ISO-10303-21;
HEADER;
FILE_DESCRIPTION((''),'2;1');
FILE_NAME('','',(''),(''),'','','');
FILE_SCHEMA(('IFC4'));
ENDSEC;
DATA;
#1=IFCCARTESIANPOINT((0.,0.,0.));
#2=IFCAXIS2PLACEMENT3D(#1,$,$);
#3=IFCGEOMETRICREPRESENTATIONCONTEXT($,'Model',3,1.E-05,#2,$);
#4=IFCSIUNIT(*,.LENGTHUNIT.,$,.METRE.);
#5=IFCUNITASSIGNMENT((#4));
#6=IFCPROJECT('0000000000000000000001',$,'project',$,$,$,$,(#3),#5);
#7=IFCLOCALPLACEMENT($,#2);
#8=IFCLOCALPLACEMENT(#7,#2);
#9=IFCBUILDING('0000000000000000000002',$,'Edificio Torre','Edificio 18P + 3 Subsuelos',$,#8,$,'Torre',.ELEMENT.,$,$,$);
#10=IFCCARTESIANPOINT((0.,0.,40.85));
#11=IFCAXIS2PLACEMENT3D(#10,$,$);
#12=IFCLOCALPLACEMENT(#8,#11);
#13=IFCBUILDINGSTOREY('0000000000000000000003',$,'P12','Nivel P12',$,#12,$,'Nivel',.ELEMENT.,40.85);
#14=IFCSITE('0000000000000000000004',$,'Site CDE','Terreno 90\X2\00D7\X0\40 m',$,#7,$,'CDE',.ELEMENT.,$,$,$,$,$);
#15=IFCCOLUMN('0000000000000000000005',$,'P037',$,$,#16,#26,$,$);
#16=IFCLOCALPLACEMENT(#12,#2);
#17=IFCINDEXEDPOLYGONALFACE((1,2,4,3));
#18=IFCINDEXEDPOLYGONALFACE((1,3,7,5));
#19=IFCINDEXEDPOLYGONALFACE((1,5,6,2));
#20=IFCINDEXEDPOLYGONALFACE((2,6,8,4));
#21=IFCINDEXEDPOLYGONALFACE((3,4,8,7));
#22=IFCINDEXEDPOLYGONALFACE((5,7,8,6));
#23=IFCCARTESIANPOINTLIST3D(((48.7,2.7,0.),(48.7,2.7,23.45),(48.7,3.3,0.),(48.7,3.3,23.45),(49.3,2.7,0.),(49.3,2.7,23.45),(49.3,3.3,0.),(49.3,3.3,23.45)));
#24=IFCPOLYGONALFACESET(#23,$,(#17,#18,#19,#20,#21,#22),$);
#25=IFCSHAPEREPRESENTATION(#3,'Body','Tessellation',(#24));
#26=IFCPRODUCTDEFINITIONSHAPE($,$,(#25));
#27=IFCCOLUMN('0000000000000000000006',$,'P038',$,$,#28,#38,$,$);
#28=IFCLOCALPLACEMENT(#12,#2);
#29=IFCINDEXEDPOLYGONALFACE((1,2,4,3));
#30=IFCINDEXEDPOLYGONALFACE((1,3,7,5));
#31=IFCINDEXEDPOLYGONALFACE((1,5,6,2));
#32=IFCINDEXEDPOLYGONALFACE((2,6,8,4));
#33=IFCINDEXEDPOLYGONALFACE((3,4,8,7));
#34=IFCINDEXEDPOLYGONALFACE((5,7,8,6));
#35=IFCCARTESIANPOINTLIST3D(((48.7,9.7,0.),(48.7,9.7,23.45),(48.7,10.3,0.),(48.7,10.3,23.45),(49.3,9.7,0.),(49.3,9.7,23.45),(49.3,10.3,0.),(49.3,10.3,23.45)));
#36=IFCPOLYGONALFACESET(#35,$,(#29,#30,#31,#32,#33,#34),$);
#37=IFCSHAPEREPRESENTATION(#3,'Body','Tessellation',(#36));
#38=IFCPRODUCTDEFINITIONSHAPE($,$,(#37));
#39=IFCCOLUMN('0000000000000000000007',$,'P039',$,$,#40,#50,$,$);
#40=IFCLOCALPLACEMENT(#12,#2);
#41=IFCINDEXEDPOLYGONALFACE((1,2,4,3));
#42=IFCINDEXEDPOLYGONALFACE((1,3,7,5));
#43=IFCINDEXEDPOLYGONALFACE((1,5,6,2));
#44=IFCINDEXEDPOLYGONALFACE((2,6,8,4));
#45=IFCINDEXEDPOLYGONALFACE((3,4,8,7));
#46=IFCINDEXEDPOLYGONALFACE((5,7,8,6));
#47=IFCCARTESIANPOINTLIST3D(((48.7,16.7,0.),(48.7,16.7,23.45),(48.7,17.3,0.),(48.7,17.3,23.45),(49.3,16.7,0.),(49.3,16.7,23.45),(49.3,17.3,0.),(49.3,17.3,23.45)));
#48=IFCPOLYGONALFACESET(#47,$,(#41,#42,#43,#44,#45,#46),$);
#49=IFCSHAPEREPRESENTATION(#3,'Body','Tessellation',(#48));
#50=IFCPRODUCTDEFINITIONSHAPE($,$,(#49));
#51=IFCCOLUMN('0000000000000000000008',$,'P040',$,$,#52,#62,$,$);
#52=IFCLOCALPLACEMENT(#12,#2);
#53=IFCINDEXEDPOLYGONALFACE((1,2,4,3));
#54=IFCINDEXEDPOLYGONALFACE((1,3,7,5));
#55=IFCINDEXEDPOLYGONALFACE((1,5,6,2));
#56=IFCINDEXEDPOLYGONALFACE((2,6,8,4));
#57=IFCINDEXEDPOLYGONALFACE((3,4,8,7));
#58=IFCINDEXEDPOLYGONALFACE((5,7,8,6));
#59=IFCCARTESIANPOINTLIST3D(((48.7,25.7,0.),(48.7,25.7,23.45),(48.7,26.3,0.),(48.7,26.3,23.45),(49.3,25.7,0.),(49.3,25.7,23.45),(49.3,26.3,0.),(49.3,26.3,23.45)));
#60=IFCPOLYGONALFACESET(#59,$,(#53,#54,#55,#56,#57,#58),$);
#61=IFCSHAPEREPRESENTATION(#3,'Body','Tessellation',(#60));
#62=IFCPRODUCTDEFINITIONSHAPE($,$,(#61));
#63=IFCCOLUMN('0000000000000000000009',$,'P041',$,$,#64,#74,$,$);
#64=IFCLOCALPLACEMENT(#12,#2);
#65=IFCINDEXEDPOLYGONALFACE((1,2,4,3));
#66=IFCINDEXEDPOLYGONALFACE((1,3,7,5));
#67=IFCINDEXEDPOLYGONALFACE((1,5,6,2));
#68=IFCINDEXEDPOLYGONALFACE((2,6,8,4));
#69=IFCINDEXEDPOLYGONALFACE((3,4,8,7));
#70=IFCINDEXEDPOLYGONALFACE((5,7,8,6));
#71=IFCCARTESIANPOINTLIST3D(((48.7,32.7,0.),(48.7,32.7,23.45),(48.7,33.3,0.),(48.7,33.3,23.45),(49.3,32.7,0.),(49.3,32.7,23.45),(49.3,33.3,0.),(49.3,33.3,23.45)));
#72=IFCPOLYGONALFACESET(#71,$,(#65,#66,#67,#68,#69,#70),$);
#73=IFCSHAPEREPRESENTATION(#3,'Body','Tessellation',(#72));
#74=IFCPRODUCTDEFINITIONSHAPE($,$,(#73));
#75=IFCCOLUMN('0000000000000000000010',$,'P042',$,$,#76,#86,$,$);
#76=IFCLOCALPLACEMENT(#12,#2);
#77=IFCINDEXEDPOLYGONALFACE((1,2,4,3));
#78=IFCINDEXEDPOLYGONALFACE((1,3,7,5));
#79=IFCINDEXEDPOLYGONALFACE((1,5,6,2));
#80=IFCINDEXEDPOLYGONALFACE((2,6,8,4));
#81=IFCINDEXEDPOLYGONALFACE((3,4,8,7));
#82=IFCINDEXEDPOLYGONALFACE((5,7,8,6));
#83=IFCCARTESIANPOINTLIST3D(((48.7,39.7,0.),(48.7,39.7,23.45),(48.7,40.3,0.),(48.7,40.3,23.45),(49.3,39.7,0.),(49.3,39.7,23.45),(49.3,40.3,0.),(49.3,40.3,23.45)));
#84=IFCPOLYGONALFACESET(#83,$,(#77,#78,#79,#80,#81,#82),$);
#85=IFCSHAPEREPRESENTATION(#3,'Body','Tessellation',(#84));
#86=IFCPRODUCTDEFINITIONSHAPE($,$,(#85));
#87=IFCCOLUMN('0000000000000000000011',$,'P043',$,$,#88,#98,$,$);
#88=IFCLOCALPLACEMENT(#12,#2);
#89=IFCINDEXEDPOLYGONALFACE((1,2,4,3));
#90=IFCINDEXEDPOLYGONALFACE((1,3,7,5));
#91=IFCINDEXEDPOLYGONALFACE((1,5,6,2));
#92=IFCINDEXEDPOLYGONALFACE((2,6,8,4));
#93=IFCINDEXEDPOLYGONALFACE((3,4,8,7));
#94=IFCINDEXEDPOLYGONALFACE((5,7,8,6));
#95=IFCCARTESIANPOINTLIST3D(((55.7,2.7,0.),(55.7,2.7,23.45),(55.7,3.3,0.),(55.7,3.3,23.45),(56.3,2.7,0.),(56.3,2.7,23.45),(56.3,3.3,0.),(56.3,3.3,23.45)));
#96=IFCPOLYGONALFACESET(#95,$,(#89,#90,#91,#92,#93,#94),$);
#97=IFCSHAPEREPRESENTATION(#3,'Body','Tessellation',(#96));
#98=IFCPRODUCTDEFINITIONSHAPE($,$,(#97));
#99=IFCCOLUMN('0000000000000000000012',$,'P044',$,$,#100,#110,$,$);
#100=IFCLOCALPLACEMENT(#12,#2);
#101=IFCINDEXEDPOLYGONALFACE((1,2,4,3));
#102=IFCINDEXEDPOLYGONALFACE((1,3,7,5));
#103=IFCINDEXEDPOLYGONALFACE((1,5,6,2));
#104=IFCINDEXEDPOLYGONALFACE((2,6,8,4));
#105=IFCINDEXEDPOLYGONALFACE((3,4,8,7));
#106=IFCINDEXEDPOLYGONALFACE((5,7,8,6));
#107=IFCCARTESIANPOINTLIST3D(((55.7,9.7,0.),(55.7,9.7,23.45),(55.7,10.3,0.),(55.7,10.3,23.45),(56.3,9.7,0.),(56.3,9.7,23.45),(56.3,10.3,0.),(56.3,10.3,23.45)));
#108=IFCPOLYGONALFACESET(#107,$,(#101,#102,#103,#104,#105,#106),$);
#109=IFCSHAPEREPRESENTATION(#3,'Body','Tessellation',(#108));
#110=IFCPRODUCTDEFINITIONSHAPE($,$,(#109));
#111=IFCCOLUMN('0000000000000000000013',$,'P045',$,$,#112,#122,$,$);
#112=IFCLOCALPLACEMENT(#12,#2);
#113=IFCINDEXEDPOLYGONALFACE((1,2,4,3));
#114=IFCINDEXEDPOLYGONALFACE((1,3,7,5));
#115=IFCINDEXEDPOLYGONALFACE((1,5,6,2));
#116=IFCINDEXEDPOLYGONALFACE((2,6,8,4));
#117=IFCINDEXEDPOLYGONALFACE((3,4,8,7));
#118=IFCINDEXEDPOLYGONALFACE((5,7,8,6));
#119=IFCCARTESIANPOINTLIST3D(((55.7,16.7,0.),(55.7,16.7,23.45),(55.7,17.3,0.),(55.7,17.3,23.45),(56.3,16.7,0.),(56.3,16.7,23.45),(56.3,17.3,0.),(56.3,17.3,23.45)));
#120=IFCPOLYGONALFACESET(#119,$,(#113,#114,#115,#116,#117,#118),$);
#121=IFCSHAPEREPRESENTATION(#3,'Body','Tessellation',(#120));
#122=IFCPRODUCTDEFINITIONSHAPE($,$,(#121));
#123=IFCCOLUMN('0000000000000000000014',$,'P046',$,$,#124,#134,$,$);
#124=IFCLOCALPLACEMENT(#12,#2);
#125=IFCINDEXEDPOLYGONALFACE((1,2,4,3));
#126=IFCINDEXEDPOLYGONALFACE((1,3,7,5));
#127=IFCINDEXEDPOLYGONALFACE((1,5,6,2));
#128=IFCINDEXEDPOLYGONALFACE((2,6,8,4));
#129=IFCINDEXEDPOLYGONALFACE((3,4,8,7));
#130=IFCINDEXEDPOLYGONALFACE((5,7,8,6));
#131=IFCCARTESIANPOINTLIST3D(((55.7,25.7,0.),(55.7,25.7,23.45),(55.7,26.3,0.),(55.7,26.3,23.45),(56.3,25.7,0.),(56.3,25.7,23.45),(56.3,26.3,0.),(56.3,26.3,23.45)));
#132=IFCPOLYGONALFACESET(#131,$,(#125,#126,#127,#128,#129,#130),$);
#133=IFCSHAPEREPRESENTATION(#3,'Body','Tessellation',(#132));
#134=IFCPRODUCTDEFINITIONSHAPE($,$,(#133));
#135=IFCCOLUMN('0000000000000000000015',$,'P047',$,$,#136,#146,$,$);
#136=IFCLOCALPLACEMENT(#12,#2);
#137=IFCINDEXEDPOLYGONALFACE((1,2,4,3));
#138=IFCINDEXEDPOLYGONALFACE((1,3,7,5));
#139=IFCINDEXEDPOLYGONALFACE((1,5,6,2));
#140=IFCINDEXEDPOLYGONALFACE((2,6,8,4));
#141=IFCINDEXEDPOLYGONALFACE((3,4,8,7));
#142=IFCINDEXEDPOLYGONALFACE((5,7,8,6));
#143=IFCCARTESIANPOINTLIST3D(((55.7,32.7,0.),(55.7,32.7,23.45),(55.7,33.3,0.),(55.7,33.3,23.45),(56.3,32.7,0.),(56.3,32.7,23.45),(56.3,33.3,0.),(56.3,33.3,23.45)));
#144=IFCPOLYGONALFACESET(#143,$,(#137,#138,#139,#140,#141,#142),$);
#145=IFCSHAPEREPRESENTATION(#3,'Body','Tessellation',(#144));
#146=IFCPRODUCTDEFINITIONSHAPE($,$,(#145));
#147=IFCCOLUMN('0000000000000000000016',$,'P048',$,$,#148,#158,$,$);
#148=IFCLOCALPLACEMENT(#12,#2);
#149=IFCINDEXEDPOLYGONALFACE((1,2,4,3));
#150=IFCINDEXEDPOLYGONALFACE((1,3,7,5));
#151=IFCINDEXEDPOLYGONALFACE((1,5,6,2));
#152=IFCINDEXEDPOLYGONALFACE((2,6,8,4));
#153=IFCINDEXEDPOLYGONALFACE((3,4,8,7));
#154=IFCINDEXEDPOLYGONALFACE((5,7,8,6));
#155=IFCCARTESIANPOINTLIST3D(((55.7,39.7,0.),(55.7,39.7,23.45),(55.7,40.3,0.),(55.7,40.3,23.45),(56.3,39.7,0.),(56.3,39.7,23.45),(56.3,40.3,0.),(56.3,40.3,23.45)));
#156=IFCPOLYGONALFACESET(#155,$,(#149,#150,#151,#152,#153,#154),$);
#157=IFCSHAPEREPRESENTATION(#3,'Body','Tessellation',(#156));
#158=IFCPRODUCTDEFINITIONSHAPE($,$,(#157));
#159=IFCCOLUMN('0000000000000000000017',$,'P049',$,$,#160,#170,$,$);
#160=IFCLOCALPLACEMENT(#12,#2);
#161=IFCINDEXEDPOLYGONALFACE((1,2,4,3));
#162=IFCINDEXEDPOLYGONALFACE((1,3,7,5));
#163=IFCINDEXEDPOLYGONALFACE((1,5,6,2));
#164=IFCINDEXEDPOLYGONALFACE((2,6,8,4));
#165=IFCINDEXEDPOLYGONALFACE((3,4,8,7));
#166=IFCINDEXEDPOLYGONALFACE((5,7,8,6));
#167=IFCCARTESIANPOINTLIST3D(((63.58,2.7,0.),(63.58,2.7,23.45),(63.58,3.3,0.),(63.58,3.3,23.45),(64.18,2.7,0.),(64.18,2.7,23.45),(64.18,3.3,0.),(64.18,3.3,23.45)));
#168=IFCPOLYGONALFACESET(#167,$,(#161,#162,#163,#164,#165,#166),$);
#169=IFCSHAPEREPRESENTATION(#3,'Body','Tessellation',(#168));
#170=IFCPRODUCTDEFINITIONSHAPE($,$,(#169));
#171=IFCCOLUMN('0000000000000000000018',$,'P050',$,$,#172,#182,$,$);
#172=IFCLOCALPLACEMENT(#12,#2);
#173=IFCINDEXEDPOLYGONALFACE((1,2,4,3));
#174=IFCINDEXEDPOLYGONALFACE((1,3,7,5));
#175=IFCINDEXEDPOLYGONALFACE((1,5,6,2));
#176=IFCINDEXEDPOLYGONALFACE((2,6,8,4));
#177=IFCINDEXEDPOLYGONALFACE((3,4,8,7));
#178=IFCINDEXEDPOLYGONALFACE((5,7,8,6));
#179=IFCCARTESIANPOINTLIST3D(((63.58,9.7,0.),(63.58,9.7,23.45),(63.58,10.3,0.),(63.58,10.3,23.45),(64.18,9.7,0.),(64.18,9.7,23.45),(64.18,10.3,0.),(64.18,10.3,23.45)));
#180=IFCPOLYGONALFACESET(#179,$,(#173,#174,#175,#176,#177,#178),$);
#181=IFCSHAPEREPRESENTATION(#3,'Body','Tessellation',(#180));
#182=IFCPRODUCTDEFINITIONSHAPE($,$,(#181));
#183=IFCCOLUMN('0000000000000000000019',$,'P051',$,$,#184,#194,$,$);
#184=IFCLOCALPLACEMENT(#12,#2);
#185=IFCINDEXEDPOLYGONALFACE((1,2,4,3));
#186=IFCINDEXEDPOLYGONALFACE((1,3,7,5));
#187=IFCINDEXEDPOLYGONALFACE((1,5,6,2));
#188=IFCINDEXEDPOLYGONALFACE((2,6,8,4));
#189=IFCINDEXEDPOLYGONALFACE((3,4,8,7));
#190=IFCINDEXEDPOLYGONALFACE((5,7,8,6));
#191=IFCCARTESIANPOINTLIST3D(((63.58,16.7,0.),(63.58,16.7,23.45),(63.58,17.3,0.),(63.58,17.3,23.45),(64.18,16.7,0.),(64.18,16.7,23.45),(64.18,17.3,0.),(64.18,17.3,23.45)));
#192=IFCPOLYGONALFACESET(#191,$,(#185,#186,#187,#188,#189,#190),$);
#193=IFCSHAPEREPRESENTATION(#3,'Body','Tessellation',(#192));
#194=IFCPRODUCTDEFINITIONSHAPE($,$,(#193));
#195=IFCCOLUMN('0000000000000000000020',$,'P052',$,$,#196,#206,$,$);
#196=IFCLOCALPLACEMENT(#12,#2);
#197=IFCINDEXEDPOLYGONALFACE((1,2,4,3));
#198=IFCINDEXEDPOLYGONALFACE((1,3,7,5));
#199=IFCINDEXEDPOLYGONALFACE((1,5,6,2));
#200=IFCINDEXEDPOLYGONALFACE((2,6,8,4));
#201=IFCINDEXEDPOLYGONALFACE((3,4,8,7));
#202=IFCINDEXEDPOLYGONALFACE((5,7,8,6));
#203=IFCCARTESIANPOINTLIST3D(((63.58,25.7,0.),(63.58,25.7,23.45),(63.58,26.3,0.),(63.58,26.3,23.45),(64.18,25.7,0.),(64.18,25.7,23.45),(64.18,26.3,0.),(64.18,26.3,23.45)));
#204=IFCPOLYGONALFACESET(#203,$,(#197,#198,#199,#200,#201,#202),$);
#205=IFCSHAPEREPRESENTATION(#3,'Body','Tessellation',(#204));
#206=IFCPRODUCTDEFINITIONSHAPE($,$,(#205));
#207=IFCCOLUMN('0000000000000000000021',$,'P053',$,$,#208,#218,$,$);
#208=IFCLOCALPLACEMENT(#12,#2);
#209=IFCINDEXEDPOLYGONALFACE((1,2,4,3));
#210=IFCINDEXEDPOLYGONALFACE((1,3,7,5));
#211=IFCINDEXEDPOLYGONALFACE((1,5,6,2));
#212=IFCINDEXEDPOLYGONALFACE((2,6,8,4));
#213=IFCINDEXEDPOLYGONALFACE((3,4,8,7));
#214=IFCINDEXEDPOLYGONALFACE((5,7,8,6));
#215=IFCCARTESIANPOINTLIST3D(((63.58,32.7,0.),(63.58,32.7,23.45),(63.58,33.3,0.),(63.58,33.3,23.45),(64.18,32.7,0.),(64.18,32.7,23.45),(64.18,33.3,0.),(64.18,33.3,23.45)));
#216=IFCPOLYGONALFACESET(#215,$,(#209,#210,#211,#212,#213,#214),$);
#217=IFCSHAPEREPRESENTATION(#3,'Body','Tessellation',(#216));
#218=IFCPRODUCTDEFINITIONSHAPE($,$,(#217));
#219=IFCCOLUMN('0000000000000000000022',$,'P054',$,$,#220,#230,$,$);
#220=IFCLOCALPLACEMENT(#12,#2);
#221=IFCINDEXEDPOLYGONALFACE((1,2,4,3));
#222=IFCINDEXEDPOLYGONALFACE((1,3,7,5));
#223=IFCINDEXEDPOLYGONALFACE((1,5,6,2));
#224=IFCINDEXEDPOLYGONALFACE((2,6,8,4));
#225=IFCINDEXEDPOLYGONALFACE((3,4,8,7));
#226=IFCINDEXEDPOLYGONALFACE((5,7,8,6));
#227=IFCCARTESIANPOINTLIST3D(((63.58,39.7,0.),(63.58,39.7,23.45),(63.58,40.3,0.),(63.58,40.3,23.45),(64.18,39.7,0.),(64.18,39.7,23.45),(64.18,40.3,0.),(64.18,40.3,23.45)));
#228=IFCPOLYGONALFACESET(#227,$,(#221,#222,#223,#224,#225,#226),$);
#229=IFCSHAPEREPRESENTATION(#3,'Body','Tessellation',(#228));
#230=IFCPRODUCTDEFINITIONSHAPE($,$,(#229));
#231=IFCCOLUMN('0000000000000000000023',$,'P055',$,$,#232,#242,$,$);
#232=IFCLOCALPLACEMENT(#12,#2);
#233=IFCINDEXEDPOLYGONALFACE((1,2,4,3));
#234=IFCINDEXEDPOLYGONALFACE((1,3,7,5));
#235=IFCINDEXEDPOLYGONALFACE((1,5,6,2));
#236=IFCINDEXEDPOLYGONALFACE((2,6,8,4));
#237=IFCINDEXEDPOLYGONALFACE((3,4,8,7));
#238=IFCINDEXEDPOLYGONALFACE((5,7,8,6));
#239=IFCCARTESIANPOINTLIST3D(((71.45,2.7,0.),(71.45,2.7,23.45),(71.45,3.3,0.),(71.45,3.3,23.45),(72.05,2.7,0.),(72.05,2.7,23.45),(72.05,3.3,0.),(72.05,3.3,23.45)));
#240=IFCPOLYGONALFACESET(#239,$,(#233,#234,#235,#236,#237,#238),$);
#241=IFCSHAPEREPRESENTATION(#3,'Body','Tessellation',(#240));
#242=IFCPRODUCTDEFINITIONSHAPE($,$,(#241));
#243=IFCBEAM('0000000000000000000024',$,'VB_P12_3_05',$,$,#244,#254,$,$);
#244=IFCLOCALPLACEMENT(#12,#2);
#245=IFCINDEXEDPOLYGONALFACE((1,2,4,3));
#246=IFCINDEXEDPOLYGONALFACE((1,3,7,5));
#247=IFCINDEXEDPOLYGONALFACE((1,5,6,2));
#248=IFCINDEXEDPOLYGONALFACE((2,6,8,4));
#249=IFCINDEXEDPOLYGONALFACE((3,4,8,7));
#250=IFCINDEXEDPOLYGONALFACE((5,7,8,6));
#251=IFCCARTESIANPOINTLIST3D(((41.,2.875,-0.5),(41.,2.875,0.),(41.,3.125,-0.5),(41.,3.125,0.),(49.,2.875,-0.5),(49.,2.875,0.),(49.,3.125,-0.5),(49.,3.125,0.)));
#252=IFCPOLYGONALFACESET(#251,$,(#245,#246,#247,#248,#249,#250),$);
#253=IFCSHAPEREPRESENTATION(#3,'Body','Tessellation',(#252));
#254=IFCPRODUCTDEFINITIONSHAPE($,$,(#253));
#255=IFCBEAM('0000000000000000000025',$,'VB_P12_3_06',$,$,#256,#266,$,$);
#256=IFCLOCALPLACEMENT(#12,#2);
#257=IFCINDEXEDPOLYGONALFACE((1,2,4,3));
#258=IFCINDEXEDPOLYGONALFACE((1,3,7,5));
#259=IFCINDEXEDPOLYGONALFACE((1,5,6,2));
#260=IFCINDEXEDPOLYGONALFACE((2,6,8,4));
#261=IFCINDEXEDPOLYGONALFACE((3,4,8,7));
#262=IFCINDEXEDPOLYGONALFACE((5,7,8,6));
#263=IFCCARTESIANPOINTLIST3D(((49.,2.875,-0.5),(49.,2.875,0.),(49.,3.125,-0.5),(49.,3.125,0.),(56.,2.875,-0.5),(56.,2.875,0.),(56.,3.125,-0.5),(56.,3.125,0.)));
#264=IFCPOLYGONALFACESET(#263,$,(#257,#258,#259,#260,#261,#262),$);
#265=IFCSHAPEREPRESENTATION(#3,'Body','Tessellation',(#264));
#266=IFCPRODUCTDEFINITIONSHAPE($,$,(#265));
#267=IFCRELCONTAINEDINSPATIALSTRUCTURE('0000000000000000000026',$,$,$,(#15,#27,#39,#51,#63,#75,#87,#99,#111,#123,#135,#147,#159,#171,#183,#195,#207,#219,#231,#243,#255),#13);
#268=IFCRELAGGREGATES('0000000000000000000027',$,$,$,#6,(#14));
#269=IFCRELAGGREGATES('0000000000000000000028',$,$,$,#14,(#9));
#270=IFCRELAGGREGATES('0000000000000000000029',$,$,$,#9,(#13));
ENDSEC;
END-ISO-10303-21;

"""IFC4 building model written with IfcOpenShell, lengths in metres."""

from ifc_helpers import new_model, si_unit, frame, origin, origin_2d, place, context, project, spatial, rectangle, extrude, element, save


model = new_model("IFC4")

# Units and contexts
model_context = context("Model", 3, precision=1e-05, world=origin())
ifc_project = project(units=[si_unit("LENGTHUNIT", "METRE")], contexts=[model_context])

# Site, building, storey
site_placement = place(None, origin())
site = spatial("IfcSite", under=ifc_project, at=site_placement, Name="Site CDE", Description="Terreno 90×40 m", LongName="CDE", CompositionType="ELEMENT")
building_placement = place(site_placement, origin())
building = spatial("IfcBuilding", under=site, at=building_placement, Name="Edificio Torre", Description="Edificio 18P + 3 Subsuelos", LongName="Torre", CompositionType="ELEMENT")
storey_placement = place(building_placement, frame((0.0, 0.0, 40.85)))
storey = spatial("IfcBuildingStorey", under=building, at=storey_placement, Name="P12", Description="Nivel P12", LongName="Nivel", CompositionType="ELEMENT", Elevation=40.85)

# Columns
for number, where, name in (
    (1, (49.0, 3.0, 0.0), "P037"),
    (2, (49.0, 10.0, 0.0), "P038"),
    (3, (49.0, 17.0, 0.0), "P039"),
    (4, (49.0, 26.0, 0.0), "P040"),
    (5, (49.0, 33.0, 0.0), "P041"),
    (6, (49.0, 40.0, 0.0), "P042"),
    (7, (56.0, 3.0, 0.0), "P043"),
    (8, (56.0, 10.0, 0.0), "P044"),
    (9, (56.0, 17.0, 0.0), "P045"),
    (10, (56.0, 26.0, 0.0), "P046"),
    (11, (56.0, 33.0, 0.0), "P047"),
    (12, (56.0, 40.0, 0.0), "P048"),
    (13, (63.88, 3.0, 0.0), "P049"),
    (14, (63.88, 10.0, 0.0), "P050"),
    (15, (63.88, 17.0, 0.0), "P051"),
    (16, (63.88, 26.0, 0.0), "P052"),
    (17, (63.88, 33.0, 0.0), "P053"),
    (18, (63.88, 40.0, 0.0), "P054"),
    (19, (71.75, 3.0, 0.0), "P055"),
):
    element("IfcColumn", number, at=place(storey_placement, frame(where)), inside=storey, Name=name, context=model_context, shape_type="SweptSolid", body=[
        extrude(rectangle(XDim=0.6, YDim=0.6, at=origin_2d()), origin(), (0.0, 0.0, 1.0), 23.45),
    ])

# Beams
beam_1_placement = place(storey_placement, frame((45.0, 3.0, -0.5)))
element("IfcBeam", 20, at=beam_1_placement, inside=storey, Name="VB_P12_3_05", context=model_context, shape_type="SweptSolid", body=[
    extrude(rectangle(XDim=8.0, YDim=0.25, at=origin_2d()), origin(), (0.0, 0.0, 1.0), 0.5),
])
beam_2_placement = place(storey_placement, frame((52.5, 3.0, -0.5)))
element("IfcBeam", 21, at=beam_2_placement, inside=storey, Name="VB_P12_3_06", context=model_context, shape_type="SweptSolid", body=[
    extrude(rectangle(XDim=7.0, YDim=0.25, at=origin_2d()), origin(), (0.0, 0.0, 1.0), 0.5),
])

save(model, "model.ifc")
